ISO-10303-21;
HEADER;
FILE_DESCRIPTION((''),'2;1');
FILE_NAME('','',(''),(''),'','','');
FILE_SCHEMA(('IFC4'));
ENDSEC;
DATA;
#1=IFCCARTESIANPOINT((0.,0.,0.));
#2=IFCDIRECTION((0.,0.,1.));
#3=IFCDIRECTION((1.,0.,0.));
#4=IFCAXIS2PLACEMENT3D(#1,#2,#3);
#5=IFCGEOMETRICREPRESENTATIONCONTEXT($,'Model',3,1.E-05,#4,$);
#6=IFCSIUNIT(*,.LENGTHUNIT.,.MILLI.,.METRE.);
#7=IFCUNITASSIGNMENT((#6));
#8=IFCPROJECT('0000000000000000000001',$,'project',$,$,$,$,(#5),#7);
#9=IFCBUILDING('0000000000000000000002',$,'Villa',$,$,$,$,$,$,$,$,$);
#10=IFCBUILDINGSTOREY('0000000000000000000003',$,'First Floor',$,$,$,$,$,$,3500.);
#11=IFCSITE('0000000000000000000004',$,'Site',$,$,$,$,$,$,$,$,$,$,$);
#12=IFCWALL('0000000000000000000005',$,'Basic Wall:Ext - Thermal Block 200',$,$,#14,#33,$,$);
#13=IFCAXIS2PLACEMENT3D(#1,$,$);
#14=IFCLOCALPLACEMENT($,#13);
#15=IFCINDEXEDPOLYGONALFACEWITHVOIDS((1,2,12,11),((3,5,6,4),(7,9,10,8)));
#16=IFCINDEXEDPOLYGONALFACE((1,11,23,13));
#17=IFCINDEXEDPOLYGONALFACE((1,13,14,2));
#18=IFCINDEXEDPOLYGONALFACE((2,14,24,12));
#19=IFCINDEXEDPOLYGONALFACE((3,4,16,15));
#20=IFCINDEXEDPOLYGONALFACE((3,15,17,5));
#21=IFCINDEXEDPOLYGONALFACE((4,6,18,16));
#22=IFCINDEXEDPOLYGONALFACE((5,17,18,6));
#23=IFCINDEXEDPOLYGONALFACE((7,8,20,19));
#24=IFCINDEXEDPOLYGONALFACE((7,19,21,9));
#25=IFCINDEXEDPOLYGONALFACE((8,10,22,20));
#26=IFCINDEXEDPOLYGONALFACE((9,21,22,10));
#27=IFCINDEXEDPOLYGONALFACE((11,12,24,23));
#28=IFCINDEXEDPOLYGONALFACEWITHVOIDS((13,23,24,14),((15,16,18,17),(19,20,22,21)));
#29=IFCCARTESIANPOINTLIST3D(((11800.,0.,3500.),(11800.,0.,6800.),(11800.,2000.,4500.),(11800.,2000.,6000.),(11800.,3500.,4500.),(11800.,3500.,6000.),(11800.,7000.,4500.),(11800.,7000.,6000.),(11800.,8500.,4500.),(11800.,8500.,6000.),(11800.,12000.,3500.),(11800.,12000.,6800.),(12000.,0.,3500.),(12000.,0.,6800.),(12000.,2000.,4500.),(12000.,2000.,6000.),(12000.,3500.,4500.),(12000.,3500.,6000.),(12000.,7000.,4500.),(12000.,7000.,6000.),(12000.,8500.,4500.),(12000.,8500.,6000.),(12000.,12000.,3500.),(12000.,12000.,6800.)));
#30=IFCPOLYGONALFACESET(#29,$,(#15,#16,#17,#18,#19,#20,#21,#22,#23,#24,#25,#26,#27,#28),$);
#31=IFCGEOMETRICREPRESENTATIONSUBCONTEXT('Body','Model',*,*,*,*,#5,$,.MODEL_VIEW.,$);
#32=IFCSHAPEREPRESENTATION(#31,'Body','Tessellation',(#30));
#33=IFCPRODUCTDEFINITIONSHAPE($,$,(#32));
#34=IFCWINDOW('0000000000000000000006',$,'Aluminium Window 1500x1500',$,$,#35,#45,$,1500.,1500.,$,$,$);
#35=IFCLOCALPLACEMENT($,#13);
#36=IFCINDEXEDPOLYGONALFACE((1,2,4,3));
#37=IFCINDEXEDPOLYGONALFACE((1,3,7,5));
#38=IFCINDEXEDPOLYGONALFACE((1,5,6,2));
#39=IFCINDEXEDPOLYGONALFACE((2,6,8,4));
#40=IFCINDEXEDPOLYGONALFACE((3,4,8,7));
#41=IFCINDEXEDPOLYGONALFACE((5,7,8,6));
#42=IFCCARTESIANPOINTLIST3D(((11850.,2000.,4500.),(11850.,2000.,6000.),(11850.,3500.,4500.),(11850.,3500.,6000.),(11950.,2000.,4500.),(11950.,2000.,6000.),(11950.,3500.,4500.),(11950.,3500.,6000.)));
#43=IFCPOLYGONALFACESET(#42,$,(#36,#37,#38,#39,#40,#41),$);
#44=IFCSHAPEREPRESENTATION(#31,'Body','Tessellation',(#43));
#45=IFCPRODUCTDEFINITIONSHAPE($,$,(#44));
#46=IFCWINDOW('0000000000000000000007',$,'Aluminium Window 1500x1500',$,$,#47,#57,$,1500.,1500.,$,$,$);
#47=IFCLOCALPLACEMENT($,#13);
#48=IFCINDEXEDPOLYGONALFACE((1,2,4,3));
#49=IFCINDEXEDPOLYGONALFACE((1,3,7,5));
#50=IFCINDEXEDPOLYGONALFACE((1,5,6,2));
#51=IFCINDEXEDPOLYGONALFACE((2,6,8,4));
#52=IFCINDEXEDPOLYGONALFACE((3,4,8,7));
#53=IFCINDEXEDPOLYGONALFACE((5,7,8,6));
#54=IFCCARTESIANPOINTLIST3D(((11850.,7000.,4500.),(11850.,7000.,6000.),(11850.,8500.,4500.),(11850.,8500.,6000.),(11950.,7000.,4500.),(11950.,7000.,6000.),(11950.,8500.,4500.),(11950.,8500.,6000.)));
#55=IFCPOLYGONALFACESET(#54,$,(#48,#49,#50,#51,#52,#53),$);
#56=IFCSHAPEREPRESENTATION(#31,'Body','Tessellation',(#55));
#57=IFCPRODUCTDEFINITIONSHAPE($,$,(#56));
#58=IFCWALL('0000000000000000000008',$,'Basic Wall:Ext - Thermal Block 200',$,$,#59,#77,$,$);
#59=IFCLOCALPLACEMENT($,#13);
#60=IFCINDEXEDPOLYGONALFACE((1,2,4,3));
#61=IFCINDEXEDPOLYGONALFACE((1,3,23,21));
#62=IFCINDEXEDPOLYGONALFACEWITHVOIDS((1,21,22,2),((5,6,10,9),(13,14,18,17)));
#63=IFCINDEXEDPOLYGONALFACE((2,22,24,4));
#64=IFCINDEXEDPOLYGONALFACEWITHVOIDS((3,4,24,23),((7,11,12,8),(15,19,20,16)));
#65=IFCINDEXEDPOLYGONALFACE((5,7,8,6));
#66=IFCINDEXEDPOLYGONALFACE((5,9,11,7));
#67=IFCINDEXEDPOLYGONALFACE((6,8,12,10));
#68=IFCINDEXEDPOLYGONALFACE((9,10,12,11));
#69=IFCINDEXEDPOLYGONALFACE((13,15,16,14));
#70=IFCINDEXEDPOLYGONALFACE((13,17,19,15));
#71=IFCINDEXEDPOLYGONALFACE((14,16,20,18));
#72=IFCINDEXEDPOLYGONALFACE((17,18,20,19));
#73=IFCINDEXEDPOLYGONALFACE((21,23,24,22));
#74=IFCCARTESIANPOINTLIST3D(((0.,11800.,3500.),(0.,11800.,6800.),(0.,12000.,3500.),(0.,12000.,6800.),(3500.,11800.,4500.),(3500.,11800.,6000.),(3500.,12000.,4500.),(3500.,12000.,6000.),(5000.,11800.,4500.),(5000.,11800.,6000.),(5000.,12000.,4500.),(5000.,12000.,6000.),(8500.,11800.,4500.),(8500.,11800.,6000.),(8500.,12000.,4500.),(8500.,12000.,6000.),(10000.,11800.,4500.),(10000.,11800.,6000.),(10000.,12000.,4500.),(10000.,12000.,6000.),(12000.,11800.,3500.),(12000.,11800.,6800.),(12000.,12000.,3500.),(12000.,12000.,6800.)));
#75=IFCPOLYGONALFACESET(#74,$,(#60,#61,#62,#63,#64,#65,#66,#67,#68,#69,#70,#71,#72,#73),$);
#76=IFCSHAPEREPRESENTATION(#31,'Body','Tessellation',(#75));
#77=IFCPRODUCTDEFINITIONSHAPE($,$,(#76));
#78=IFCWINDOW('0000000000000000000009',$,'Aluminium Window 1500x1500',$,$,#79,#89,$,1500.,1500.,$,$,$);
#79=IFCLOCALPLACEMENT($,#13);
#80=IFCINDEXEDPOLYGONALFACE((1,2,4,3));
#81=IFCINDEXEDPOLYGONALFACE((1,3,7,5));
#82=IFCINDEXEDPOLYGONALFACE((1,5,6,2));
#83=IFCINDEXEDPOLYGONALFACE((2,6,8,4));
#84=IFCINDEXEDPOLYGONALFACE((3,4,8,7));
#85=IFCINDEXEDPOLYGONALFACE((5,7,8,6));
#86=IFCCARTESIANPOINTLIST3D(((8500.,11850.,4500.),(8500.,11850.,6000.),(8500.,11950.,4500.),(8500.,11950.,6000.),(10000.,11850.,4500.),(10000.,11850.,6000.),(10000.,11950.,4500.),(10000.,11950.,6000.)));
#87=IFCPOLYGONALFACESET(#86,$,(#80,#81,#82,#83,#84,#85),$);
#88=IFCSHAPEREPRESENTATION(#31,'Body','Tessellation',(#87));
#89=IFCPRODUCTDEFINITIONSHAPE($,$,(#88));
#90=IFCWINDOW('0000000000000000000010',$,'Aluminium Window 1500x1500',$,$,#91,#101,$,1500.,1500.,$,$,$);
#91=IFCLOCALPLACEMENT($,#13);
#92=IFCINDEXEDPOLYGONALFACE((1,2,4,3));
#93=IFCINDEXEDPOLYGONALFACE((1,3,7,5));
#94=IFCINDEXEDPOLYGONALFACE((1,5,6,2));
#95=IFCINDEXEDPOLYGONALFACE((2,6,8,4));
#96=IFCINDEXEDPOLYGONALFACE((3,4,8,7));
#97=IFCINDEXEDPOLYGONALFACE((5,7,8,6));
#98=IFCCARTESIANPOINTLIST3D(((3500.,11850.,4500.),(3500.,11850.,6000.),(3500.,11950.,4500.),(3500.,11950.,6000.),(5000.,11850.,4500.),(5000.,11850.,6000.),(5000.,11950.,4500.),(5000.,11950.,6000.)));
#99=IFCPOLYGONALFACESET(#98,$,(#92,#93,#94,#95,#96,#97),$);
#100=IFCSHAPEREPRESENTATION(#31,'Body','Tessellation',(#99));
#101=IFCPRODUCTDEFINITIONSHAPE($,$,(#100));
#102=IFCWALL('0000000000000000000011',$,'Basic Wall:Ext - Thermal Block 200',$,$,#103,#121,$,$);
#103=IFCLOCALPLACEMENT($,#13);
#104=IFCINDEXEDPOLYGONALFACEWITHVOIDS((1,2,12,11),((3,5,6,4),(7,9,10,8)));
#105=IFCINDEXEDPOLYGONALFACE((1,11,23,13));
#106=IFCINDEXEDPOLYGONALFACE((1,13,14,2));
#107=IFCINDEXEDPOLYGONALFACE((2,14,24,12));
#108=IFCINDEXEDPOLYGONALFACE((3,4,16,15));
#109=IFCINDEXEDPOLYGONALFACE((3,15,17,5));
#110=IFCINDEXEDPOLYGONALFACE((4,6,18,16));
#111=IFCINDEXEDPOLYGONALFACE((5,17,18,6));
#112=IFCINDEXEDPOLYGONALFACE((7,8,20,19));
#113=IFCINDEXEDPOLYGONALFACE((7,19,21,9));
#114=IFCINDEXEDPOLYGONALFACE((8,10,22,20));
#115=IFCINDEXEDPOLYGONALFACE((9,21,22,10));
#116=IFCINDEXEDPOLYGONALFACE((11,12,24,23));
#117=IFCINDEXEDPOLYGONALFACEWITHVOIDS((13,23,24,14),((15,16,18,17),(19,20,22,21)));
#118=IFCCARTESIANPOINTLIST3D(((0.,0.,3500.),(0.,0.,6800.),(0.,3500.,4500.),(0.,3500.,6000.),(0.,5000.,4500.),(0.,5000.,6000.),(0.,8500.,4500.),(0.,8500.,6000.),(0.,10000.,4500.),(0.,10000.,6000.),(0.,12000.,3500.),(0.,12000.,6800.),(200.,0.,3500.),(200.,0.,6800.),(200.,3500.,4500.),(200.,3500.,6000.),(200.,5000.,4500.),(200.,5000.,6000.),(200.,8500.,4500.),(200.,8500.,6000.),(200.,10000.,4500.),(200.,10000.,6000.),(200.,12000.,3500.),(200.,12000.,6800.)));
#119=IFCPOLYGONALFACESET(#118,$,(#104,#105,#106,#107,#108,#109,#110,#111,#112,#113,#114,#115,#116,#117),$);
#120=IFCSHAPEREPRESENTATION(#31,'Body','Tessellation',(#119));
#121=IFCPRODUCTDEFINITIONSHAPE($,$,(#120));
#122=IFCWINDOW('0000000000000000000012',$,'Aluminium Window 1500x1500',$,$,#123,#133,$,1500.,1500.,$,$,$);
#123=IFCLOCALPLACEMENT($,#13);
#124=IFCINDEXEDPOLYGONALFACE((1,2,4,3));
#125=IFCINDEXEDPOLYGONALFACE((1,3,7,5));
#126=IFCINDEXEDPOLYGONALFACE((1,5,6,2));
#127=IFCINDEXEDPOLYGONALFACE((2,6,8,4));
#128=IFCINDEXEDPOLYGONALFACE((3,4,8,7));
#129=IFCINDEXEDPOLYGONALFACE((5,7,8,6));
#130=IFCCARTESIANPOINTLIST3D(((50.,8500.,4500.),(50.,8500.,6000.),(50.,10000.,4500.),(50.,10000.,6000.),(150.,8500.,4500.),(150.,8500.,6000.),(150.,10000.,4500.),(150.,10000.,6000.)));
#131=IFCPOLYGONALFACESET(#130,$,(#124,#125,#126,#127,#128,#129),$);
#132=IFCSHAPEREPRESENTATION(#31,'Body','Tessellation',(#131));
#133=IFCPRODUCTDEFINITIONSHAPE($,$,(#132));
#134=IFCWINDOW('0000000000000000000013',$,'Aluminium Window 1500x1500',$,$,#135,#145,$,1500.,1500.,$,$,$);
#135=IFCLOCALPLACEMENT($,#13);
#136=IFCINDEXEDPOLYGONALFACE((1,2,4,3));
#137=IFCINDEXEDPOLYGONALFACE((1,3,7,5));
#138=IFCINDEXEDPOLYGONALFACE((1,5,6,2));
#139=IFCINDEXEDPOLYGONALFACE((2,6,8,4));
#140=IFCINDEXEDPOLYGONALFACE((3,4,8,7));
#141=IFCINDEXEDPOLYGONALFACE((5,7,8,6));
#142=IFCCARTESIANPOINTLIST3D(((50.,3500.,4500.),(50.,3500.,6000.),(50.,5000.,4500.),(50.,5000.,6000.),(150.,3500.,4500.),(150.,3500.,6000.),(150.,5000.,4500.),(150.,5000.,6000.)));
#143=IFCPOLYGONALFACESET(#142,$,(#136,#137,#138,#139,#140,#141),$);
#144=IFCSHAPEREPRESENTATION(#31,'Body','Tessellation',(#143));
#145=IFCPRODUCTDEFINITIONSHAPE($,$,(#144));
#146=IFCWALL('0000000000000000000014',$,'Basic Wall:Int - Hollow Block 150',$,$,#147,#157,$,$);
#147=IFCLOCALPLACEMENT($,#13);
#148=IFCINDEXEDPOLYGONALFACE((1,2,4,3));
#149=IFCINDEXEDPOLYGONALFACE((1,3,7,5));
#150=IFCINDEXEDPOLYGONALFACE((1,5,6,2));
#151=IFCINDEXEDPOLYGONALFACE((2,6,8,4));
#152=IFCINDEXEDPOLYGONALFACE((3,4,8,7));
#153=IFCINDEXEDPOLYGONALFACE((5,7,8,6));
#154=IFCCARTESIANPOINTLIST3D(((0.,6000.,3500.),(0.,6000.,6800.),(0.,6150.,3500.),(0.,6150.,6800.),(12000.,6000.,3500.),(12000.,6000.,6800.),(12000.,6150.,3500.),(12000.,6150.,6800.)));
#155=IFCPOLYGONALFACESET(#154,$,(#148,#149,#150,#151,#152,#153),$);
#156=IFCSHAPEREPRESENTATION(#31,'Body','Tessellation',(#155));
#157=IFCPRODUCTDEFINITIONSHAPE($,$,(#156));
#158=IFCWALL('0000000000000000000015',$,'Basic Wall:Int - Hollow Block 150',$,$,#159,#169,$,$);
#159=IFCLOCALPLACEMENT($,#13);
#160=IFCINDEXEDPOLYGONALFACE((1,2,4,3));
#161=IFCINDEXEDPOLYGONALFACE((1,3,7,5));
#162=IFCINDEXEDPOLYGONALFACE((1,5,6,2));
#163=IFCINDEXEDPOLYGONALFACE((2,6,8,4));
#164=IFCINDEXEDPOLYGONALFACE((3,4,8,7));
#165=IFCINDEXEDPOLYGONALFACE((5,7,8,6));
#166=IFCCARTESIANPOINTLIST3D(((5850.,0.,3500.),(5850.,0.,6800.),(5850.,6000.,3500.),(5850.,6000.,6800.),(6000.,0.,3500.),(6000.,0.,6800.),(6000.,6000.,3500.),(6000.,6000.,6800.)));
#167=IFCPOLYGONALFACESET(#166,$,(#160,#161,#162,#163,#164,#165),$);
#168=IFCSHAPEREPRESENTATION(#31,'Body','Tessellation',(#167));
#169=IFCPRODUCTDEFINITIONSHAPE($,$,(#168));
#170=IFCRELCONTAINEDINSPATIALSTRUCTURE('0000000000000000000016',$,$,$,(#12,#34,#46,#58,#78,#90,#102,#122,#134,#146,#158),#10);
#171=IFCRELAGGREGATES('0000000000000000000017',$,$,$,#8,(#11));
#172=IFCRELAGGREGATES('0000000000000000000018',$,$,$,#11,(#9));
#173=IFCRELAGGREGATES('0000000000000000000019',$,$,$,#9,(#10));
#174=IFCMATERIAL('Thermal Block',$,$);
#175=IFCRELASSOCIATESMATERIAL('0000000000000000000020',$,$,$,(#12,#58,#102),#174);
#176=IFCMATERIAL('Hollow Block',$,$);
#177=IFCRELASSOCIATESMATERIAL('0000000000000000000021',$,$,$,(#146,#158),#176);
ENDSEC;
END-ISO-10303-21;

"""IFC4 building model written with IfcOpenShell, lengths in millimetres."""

from ifc_helpers import new_model, si_unit, frame, origin_with_axes, place, context, subcontext, project, spatial, indexed_curve, outline, extrude, material, element, fill, save


model = new_model("IFC4")

# Units and contexts
model_context = context("Model", 3, precision=1e-05, world=origin_with_axes())
body_context = subcontext(model_context, "Body", "Model", "MODEL_VIEW")
ifc_project = project(units=[si_unit("LENGTHUNIT", "METRE", prefix="MILLI")], contexts=[model_context])

# Site, building, storey
site = spatial("IfcSite", under=ifc_project, Name="Site")
building = spatial("IfcBuilding", under=site, Name="Villa")
storey = spatial("IfcBuildingStorey", under=building, Name="First Floor", Elevation=3500.0)

# Walls, openings, windows
ifc_material_1 = material(Name="Thermal Block")
wall_1_placement = place(None, frame((12000.0, 0.0, 3500.0), z_axis=(0.0, 0.0, 1.0), x_axis=(0.0, 1.0, 0.0)))
wall_1 = element("IfcWall", 1, at=wall_1_placement, inside=storey, material=ifc_material_1, Name="Basic Wall:Ext - Thermal Block 200", context=body_context, shape_type="SweptSolid", body=[
    extrude(outline(indexed_curve([(0.0, 0.0), (0.0, 200.0), (12000.0, 200.0), (12000.0, 0.0), (0.0, 0.0)], self_intersect=False)), origin_with_axes(), (0.0, 0.0, 1.0), 3300.0),
])
opening_1_placement = place(wall_1_placement, frame((2000.0, -200.0, 1000.0), z_axis=(0.0, 0.0, 1.0), x_axis=(1.0, 0.0, 0.0)))
opening_1 = element("IfcOpeningElement", 2, at=opening_1_placement, cuts=wall_1, context=body_context, shape_type="SweptSolid", body=[
    extrude(outline(indexed_curve([(0.0, 0.0), (0.0, 600.0), (1500.0, 600.0), (1500.0, 0.0), (0.0, 0.0)], self_intersect=False)), origin_with_axes(), (0.0, 0.0, 1.0), 1500.0),
])
opening_2_placement = place(wall_1_placement, frame((7000.0, -200.0, 1000.0), z_axis=(0.0, 0.0, 1.0), x_axis=(1.0, 0.0, 0.0)))
opening_2 = element("IfcOpeningElement", 3, at=opening_2_placement, cuts=wall_1, context=body_context, shape_type="SweptSolid", body=[
    extrude(outline(indexed_curve([(0.0, 0.0), (0.0, 600.0), (1500.0, 600.0), (1500.0, 0.0), (0.0, 0.0)], self_intersect=False)), origin_with_axes(), (0.0, 0.0, 1.0), 1500.0),
])
window_1_placement = place(None, frame((11950.0, 2000.0, 4500.0), z_axis=(0.0, 0.0, 1.0), x_axis=(0.0, 1.0, 0.0)))
window_1 = element("IfcWindow", 4, at=window_1_placement, inside=storey, Name="Aluminium Window 1500x1500", OverallHeight=1500.0, OverallWidth=1500.0, context=body_context, shape_type="SweptSolid", body=[
    extrude(outline(indexed_curve([(0.0, 0.0), (0.0, 100.0), (1500.0, 100.0), (1500.0, 0.0), (0.0, 0.0)], self_intersect=False)), origin_with_axes(), (0.0, 0.0, 1.0), 1500.0),
])
fill(opening_1, window_1)
window_2_placement = place(None, frame((11950.0, 7000.0, 4500.0), z_axis=(0.0, 0.0, 1.0), x_axis=(0.0, 1.0, 0.0)))
window_2 = element("IfcWindow", 5, at=window_2_placement, inside=storey, Name="Aluminium Window 1500x1500", OverallHeight=1500.0, OverallWidth=1500.0, context=body_context, shape_type="SweptSolid", body=[
    extrude(outline(indexed_curve([(0.0, 0.0), (0.0, 100.0), (1500.0, 100.0), (1500.0, 0.0), (0.0, 0.0)], self_intersect=False)), origin_with_axes(), (0.0, 0.0, 1.0), 1500.0),
])
fill(opening_2, window_2)
wall_2_placement = place(None, frame((12000.0, 12000.0, 3500.0), z_axis=(0.0, 0.0, 1.0), x_axis=(-1.0, 0.0, 0.0)))
wall_2 = element("IfcWall", 6, at=wall_2_placement, inside=storey, material=ifc_material_1, Name="Basic Wall:Ext - Thermal Block 200", context=body_context, shape_type="SweptSolid", body=[
    extrude(outline(indexed_curve([(0.0, 0.0), (0.0, 200.0), (12000.0, 200.0), (12000.0, 0.0), (0.0, 0.0)], self_intersect=False)), origin_with_axes(), (0.0, 0.0, 1.0), 3300.0),
])
opening_3_placement = place(wall_2_placement, frame((2000.0, -200.0, 1000.0), z_axis=(0.0, 0.0, 1.0), x_axis=(1.0, 0.0, 0.0)))
opening_3 = element("IfcOpeningElement", 7, at=opening_3_placement, cuts=wall_2, context=body_context, shape_type="SweptSolid", body=[
    extrude(outline(indexed_curve([(0.0, 0.0), (0.0, 600.0), (1500.0, 600.0), (1500.0, 0.0), (0.0, 0.0)], self_intersect=False)), origin_with_axes(), (0.0, 0.0, 1.0), 1500.0),
])
opening_4_placement = place(wall_2_placement, frame((7000.0, -200.0, 1000.0), z_axis=(0.0, 0.0, 1.0), x_axis=(1.0, 0.0, 0.0)))
opening_4 = element("IfcOpeningElement", 8, at=opening_4_placement, cuts=wall_2, context=body_context, shape_type="SweptSolid", body=[
    extrude(outline(indexed_curve([(0.0, 0.0), (0.0, 600.0), (1500.0, 600.0), (1500.0, 0.0), (0.0, 0.0)], self_intersect=False)), origin_with_axes(), (0.0, 0.0, 1.0), 1500.0),
])
window_3_placement = place(None, frame((10000.0, 11950.0, 4500.0), z_axis=(0.0, 0.0, 1.0), x_axis=(-1.0, 0.0, 0.0)))
window_3 = element("IfcWindow", 9, at=window_3_placement, inside=storey, Name="Aluminium Window 1500x1500", OverallHeight=1500.0, OverallWidth=1500.0, context=body_context, shape_type="SweptSolid", body=[
    extrude(outline(indexed_curve([(0.0, 0.0), (0.0, 100.0), (1500.0, 100.0), (1500.0, 0.0), (0.0, 0.0)], self_intersect=False)), origin_with_axes(), (0.0, 0.0, 1.0), 1500.0),
])
fill(opening_3, window_3)
window_4_placement = place(None, frame((5000.0, 11950.0, 4500.0), z_axis=(0.0, 0.0, 1.0), x_axis=(-1.0, 0.0, 0.0)))
window_4 = element("IfcWindow", 10, at=window_4_placement, inside=storey, Name="Aluminium Window 1500x1500", OverallHeight=1500.0, OverallWidth=1500.0, context=body_context, shape_type="SweptSolid", body=[
    extrude(outline(indexed_curve([(0.0, 0.0), (0.0, 100.0), (1500.0, 100.0), (1500.0, 0.0), (0.0, 0.0)], self_intersect=False)), origin_with_axes(), (0.0, 0.0, 1.0), 1500.0),
])
fill(opening_4, window_4)
wall_3_placement = place(None, frame((0.0, 12000.0, 3500.0), z_axis=(0.0, 0.0, 1.0), x_axis=(0.0, -1.0, 0.0)))
wall_3 = element("IfcWall", 11, at=wall_3_placement, inside=storey, material=ifc_material_1, Name="Basic Wall:Ext - Thermal Block 200", context=body_context, shape_type="SweptSolid", body=[
    extrude(outline(indexed_curve([(0.0, 0.0), (0.0, 200.0), (12000.0, 200.0), (12000.0, 0.0), (0.0, 0.0)], self_intersect=False)), origin_with_axes(), (0.0, 0.0, 1.0), 3300.0),
])
opening_5_placement = place(wall_3_placement, frame((2000.0, -200.0, 1000.0), z_axis=(0.0, 0.0, 1.0), x_axis=(1.0, 0.0, 0.0)))
opening_5 = element("IfcOpeningElement", 12, at=opening_5_placement, cuts=wall_3, context=body_context, shape_type="SweptSolid", body=[
    extrude(outline(indexed_curve([(0.0, 0.0), (0.0, 600.0), (1500.0, 600.0), (1500.0, 0.0), (0.0, 0.0)], self_intersect=False)), origin_with_axes(), (0.0, 0.0, 1.0), 1500.0),
])
opening_6_placement = place(wall_3_placement, frame((7000.0, -200.0, 1000.0), z_axis=(0.0, 0.0, 1.0), x_axis=(1.0, 0.0, 0.0)))
opening_6 = element("IfcOpeningElement", 13, at=opening_6_placement, cuts=wall_3, context=body_context, shape_type="SweptSolid", body=[
    extrude(outline(indexed_curve([(0.0, 0.0), (0.0, 600.0), (1500.0, 600.0), (1500.0, 0.0), (0.0, 0.0)], self_intersect=False)), origin_with_axes(), (0.0, 0.0, 1.0), 1500.0),
])
window_5_placement = place(None, frame((50.0, 10000.0, 4500.0), z_axis=(0.0, 0.0, 1.0), x_axis=(0.0, -1.0, 0.0)))
window_5 = element("IfcWindow", 14, at=window_5_placement, inside=storey, Name="Aluminium Window 1500x1500", OverallHeight=1500.0, OverallWidth=1500.0, context=body_context, shape_type="SweptSolid", body=[
    extrude(outline(indexed_curve([(0.0, 0.0), (0.0, 100.0), (1500.0, 100.0), (1500.0, 0.0), (0.0, 0.0)], self_intersect=False)), origin_with_axes(), (0.0, 0.0, 1.0), 1500.0),
])
fill(opening_5, window_5)
window_6_placement = place(None, frame((50.0, 5000.0, 4500.0), z_axis=(0.0, 0.0, 1.0), x_axis=(0.0, -1.0, 0.0)))
window_6 = element("IfcWindow", 15, at=window_6_placement, inside=storey, Name="Aluminium Window 1500x1500", OverallHeight=1500.0, OverallWidth=1500.0, context=body_context, shape_type="SweptSolid", body=[
    extrude(outline(indexed_curve([(0.0, 0.0), (0.0, 100.0), (1500.0, 100.0), (1500.0, 0.0), (0.0, 0.0)], self_intersect=False)), origin_with_axes(), (0.0, 0.0, 1.0), 1500.0),
])
fill(opening_6, window_6)

# Walls
ifc_material_2 = material(Name="Hollow Block")
wall_4_placement = place(None, frame((0.0, 6000.0, 3500.0), z_axis=(0.0, 0.0, 1.0), x_axis=(1.0, 0.0, 0.0)))
element("IfcWall", 16, at=wall_4_placement, inside=storey, material=ifc_material_2, Name="Basic Wall:Int - Hollow Block 150", context=body_context, shape_type="SweptSolid", body=[
    extrude(outline(indexed_curve([(0.0, 0.0), (0.0, 150.0), (12000.0, 150.0), (12000.0, 0.0), (0.0, 0.0)], self_intersect=False)), origin_with_axes(), (0.0, 0.0, 1.0), 3300.0),
])
wall_5_placement = place(None, frame((6000.0, 0.0, 3500.0), z_axis=(0.0, 0.0, 1.0), x_axis=(0.0, 1.0, 0.0)))
element("IfcWall", 17, at=wall_5_placement, inside=storey, material=ifc_material_2, Name="Basic Wall:Int - Hollow Block 150", context=body_context, shape_type="SweptSolid", body=[
    extrude(outline(indexed_curve([(0.0, 0.0), (0.0, 150.0), (6000.0, 150.0), (6000.0, 0.0), (0.0, 0.0)], self_intersect=False)), origin_with_axes(), (0.0, 0.0, 1.0), 3300.0),
])

save(model, "model.ifc")
